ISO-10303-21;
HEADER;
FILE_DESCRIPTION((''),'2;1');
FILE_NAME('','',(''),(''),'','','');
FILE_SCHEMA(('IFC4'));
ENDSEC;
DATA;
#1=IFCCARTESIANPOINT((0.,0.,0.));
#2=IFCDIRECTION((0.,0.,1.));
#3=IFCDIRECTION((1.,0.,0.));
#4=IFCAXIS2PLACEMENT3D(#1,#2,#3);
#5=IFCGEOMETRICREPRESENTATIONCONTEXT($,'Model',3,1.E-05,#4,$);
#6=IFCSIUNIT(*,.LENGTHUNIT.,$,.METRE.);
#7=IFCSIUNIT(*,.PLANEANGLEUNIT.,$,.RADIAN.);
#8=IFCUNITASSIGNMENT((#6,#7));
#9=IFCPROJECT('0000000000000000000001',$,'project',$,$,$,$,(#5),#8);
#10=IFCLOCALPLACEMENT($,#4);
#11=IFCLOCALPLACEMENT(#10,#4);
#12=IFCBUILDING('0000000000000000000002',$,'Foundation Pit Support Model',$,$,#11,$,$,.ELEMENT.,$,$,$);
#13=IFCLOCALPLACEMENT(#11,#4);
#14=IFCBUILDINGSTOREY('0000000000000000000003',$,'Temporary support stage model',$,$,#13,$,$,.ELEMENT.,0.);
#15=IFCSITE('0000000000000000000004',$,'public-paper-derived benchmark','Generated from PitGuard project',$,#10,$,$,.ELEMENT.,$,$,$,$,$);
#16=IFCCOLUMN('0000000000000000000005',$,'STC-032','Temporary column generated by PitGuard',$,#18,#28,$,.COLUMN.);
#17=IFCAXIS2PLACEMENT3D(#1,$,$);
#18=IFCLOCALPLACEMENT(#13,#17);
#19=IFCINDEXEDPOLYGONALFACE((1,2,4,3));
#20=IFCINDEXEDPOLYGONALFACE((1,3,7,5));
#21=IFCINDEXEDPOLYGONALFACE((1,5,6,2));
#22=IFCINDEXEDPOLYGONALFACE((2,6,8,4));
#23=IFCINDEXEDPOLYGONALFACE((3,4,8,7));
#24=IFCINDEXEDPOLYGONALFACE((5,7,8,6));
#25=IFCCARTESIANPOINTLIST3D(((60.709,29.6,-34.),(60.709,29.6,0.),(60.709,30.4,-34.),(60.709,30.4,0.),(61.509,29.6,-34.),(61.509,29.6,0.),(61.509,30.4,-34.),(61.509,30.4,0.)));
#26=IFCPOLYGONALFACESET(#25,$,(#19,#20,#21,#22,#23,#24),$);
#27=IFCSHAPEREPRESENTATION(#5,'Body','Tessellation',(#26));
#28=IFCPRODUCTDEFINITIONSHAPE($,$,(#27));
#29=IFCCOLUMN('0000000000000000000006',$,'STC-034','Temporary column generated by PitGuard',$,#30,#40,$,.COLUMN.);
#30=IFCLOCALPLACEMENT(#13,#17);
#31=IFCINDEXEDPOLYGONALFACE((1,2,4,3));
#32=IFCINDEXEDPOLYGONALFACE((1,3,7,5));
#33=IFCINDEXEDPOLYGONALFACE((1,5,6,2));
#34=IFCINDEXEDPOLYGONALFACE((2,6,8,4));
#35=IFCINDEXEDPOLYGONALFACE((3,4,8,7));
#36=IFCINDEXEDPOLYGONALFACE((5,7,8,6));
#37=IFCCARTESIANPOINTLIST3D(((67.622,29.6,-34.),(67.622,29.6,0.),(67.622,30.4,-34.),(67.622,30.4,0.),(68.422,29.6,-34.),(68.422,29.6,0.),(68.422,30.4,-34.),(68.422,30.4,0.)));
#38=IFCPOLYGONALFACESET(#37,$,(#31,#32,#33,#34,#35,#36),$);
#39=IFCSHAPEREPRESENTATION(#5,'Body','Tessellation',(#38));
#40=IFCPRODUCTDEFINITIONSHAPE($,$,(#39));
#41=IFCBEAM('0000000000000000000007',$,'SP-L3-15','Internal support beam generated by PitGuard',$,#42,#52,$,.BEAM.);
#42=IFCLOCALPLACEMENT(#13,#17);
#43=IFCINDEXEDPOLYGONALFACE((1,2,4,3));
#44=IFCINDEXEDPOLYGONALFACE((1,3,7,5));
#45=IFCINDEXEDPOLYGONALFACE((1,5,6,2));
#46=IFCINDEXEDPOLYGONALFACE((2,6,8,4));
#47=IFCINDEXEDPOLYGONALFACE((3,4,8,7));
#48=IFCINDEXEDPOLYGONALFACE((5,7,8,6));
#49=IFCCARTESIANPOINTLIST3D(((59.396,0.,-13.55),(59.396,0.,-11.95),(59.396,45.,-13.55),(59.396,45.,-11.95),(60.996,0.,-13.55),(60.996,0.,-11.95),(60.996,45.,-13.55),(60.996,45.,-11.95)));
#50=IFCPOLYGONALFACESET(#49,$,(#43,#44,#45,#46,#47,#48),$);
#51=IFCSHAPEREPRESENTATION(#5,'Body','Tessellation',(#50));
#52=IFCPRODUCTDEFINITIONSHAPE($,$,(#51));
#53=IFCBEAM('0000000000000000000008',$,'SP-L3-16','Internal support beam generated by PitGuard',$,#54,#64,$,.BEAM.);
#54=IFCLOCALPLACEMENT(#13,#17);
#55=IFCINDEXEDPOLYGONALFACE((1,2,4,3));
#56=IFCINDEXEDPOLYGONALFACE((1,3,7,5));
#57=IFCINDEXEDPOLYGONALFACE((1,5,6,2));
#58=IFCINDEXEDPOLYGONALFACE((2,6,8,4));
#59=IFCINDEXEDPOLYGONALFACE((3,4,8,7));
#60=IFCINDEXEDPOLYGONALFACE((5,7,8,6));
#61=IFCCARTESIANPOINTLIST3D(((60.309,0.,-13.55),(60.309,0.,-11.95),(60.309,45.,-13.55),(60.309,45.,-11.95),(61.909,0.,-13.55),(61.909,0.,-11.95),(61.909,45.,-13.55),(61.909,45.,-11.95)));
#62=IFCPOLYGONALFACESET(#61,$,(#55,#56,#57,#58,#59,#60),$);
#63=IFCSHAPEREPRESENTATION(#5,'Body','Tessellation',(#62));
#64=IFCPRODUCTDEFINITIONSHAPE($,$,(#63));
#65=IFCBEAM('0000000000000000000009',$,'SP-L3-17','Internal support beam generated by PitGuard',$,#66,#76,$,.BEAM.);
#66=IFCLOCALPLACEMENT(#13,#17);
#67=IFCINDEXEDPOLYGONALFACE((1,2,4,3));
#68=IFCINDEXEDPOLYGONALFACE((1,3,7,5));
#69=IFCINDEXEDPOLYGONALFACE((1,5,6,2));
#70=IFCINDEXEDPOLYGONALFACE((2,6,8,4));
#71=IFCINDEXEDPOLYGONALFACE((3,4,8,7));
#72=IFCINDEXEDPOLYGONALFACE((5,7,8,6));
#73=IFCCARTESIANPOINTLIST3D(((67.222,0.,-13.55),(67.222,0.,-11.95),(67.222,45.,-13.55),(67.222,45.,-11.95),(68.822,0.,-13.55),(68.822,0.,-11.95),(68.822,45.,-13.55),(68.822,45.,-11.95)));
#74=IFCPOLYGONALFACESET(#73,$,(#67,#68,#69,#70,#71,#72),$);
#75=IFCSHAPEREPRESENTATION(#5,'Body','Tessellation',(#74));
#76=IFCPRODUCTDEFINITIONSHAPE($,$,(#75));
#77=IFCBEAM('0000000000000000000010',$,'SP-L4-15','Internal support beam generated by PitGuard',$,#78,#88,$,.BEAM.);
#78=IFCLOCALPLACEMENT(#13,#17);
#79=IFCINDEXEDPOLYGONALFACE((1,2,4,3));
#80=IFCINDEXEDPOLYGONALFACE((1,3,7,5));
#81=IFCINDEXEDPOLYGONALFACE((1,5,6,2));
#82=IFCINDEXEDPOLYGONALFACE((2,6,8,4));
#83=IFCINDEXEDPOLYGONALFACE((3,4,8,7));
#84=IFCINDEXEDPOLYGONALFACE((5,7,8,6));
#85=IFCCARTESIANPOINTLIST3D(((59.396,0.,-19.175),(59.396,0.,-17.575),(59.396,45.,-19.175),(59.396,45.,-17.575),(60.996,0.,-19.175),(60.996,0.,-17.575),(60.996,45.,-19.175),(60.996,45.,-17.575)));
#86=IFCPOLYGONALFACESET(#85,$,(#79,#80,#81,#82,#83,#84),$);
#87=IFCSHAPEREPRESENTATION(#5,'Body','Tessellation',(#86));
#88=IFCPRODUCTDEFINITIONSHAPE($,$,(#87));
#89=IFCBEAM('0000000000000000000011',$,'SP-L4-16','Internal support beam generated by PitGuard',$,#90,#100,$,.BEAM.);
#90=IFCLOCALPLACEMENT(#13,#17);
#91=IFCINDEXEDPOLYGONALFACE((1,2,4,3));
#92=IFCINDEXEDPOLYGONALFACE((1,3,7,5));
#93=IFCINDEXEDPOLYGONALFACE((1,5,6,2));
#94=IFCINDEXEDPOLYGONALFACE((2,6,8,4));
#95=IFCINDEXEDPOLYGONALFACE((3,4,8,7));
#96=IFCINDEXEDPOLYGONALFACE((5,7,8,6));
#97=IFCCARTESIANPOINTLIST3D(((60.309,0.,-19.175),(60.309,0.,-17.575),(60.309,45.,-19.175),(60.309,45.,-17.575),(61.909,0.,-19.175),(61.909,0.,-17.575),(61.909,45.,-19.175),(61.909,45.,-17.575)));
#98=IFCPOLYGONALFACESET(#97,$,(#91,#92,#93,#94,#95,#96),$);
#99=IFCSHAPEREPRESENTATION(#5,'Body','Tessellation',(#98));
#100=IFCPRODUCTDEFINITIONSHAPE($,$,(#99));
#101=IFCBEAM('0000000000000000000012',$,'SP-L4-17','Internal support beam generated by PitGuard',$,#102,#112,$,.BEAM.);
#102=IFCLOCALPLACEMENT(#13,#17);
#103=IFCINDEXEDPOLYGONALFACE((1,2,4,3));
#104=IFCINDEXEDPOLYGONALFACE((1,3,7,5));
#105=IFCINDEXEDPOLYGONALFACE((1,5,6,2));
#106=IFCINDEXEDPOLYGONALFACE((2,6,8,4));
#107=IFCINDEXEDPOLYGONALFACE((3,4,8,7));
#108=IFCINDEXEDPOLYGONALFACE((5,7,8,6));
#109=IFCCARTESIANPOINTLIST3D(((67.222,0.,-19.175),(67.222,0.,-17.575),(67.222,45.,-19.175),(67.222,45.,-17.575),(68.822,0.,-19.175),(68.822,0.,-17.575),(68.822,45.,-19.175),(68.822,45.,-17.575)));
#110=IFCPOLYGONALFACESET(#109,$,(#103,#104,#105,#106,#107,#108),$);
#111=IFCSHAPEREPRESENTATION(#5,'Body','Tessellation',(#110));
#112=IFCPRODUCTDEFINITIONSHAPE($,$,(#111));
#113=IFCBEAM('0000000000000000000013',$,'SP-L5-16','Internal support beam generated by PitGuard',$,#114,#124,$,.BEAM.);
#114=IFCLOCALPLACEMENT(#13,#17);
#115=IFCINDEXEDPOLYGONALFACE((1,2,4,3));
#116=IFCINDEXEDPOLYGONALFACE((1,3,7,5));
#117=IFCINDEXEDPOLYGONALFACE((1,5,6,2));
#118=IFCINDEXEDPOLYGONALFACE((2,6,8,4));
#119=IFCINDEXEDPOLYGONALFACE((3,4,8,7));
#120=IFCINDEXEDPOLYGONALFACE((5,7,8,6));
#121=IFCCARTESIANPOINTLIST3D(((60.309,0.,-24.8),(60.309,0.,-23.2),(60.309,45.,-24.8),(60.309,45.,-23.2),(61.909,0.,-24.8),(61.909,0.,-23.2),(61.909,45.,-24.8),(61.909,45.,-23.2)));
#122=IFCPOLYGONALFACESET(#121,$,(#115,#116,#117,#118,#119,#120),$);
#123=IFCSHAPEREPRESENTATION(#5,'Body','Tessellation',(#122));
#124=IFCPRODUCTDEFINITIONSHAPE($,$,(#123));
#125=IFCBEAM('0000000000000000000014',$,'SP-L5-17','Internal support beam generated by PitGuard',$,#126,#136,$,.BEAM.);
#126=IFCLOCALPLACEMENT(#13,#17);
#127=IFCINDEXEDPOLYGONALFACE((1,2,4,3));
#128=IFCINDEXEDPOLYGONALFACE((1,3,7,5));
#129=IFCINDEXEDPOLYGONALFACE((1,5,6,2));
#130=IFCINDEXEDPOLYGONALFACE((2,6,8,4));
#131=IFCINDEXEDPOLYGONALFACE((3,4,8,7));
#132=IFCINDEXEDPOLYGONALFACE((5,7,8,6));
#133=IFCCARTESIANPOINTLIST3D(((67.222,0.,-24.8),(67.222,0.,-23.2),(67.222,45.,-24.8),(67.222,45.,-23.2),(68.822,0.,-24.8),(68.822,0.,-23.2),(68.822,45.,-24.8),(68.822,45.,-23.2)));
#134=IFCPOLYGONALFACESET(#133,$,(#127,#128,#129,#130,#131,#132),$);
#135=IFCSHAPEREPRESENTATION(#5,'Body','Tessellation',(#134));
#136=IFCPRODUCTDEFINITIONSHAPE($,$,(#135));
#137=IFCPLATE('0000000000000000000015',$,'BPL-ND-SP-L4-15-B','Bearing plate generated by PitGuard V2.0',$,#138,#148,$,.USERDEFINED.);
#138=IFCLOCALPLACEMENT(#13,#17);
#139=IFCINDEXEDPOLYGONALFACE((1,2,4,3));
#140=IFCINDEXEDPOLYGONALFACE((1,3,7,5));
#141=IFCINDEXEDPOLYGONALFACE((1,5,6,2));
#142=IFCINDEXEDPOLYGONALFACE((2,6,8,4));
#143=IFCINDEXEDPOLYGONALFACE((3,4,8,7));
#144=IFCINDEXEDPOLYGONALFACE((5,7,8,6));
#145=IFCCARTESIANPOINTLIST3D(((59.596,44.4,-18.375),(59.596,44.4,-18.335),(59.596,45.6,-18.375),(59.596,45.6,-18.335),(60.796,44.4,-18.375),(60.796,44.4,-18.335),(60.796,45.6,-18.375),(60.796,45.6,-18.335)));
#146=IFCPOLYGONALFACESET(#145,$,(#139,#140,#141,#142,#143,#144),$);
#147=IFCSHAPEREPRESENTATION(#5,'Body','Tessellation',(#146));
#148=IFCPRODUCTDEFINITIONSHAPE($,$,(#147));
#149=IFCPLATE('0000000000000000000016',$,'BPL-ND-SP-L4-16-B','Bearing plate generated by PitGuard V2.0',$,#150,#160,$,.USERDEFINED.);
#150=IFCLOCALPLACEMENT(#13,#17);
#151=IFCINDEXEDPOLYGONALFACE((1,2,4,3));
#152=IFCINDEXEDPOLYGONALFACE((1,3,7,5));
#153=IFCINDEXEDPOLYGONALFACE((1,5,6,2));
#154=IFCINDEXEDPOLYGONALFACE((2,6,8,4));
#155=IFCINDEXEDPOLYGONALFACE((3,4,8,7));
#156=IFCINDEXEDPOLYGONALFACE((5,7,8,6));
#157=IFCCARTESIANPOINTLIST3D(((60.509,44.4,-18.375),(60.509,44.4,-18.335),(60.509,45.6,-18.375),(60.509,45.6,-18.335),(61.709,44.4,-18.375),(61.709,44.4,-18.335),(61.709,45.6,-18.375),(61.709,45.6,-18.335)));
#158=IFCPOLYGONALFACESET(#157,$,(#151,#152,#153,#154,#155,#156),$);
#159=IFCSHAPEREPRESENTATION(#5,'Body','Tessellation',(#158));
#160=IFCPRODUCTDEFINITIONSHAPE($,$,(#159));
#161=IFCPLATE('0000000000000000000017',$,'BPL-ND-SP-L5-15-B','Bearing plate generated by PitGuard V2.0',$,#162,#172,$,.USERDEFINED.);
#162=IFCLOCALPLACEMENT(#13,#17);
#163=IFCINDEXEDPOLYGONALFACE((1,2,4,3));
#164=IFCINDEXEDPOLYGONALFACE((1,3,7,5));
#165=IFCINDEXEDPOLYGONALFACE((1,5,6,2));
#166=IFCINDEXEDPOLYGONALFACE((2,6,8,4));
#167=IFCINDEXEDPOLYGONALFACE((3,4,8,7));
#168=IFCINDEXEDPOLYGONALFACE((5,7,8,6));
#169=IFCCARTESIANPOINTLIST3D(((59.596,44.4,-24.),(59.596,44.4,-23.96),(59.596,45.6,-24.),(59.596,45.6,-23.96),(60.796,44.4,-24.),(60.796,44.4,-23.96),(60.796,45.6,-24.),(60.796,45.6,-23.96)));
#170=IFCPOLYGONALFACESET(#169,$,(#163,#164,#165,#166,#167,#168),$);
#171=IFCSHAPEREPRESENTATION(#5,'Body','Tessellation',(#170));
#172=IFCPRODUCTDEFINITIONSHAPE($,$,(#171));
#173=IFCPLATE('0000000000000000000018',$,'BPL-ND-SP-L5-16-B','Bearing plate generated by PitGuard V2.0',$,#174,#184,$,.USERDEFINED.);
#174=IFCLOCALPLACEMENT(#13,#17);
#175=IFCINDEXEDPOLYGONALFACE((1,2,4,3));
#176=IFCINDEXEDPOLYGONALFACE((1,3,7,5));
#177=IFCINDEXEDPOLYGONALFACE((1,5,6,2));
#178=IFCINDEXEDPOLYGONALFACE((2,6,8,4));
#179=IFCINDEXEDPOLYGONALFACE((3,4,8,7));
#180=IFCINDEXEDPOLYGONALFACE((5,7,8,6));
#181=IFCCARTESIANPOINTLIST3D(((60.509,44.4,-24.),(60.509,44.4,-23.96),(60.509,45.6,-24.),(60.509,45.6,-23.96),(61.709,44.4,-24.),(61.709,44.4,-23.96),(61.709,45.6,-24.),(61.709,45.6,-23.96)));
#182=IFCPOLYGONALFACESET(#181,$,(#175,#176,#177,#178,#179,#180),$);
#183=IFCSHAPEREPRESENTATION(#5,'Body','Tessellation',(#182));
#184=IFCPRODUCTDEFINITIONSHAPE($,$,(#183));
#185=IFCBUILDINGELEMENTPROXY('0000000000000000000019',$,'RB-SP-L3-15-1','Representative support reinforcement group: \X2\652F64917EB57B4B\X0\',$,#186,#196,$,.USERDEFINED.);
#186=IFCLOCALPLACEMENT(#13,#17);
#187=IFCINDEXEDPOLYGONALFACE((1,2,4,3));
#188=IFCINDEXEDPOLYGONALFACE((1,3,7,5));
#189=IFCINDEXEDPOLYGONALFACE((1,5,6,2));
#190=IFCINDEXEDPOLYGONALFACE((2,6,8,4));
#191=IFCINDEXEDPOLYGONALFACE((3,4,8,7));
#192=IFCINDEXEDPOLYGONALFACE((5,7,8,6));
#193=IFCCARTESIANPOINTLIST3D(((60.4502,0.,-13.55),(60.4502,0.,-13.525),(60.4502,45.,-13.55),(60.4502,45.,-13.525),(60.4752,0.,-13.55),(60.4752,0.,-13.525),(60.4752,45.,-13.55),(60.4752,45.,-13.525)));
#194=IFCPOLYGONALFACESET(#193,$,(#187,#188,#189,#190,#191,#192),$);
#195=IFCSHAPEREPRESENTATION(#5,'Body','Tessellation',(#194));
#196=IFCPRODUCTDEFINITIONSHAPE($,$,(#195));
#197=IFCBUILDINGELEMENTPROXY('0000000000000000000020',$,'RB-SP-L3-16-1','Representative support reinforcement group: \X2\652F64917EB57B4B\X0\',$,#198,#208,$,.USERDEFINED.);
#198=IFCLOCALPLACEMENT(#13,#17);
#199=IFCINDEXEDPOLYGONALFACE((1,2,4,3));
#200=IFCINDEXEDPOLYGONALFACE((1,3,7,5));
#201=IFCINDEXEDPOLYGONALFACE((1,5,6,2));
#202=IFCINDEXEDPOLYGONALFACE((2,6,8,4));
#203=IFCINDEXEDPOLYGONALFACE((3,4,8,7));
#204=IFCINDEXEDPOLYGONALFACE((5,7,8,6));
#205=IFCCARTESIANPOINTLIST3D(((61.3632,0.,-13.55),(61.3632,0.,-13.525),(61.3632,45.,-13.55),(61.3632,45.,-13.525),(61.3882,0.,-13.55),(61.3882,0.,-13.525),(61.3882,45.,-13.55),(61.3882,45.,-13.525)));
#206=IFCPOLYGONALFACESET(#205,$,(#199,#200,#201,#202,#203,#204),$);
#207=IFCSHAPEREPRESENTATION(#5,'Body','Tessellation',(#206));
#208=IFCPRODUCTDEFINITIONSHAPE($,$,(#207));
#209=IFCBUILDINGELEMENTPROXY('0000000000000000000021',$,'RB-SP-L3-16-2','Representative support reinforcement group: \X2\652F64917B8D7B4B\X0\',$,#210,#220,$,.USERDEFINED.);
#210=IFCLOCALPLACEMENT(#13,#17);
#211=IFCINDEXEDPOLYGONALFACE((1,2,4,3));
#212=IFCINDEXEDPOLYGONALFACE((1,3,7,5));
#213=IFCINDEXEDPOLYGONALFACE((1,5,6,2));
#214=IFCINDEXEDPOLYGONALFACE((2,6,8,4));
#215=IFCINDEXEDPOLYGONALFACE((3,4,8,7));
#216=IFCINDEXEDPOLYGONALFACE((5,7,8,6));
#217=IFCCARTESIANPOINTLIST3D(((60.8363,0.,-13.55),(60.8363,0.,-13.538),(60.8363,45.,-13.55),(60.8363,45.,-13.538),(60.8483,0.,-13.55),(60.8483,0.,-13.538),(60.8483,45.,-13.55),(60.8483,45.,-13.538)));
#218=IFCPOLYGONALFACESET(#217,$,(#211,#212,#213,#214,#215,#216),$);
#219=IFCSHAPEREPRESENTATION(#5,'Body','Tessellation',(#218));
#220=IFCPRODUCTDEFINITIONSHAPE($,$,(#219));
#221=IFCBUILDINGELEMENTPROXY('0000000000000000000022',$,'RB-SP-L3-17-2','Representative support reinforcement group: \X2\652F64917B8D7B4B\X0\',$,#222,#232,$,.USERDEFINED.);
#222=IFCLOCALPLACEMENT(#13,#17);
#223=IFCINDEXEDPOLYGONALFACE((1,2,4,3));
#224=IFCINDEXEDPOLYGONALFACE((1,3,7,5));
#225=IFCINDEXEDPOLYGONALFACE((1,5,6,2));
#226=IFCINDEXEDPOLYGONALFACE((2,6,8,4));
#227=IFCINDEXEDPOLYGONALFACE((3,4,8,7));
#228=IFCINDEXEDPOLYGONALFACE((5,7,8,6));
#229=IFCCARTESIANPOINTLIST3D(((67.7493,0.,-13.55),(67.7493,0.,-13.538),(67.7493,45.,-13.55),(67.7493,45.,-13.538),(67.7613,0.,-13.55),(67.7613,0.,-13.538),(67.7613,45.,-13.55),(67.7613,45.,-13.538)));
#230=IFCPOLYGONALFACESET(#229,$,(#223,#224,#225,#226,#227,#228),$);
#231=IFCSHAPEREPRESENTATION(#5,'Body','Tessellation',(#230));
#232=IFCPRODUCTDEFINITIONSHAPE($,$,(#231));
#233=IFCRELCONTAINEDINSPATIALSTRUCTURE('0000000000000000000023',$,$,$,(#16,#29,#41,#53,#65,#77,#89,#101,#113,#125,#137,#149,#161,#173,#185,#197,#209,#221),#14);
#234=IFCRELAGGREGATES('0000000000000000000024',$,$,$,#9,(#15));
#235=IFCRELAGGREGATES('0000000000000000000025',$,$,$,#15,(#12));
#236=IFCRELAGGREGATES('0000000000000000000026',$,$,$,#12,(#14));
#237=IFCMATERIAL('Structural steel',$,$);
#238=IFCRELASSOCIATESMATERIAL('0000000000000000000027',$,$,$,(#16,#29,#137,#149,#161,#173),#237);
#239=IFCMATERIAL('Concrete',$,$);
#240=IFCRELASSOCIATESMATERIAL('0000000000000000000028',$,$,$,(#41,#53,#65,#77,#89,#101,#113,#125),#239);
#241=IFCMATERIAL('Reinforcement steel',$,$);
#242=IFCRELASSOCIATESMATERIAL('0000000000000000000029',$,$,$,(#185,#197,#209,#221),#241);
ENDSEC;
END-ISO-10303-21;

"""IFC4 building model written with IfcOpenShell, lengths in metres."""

from ifc_helpers import new_model, si_unit, frame, origin_with_axes, origin_2d, place, context, project, spatial, rectangle, extrude, material, element, save


model = new_model("IFC4")

# Units and contexts
model_context = context("Model", 3, precision=1e-05, world=origin_with_axes())
ifc_project = project(units=[si_unit("LENGTHUNIT", "METRE"), si_unit("PLANEANGLEUNIT", "RADIAN")], contexts=[model_context])

# Site, building, storey
site_placement = place(None, origin_with_axes())
site = spatial("IfcSite", under=ifc_project, at=site_placement, Name="public-paper-derived benchmark", Description="Generated from PitGuard project", CompositionType="ELEMENT")
building_placement = place(site_placement, origin_with_axes())
building = spatial("IfcBuilding", under=site, at=building_placement, Name="Foundation Pit Support Model", CompositionType="ELEMENT")
storey_placement = place(building_placement, origin_with_axes())
storey = spatial("IfcBuildingStorey", under=building, at=storey_placement, Name="Temporary support stage model", CompositionType="ELEMENT", Elevation=0.0)

# Columns
ifc_material_1 = material(Name="Structural steel")
for number, where, z_axis, x_axis, name in (
    (1, (61.109, 30.0, -34.0), (0.0, 0.0, 1.0), (1.0, 0.0, 0.0), "STC-032"),
    (2, (68.022, 30.0, -34.0), (0.0, 0.0, 1.0), (1.0, 0.0, 0.0), "STC-034"),
):
    element("IfcColumn", number, at=place(storey_placement, frame(where, z_axis=z_axis, x_axis=x_axis)), inside=storey, material=ifc_material_1, Name=name, Description="Temporary column generated by PitGuard", PredefinedType="COLUMN", context=model_context, shape_type="SweptSolid", body=[
        extrude(rectangle(XDim=0.8, YDim=0.8, at=origin_2d()), origin_with_axes(), (0.0, 0.0, 1.0), 34.0),
    ])

# Beams
ifc_material_2 = material(Name="Concrete")
for number, where, z_axis, x_axis, name in (
    (3, (60.196, 22.5, -13.55), (0.0, 0.0, 1.0), (0.0, 1.0, 0.0), "SP-L3-15"),
    (4, (61.109, 22.5, -13.55), (0.0, 0.0, 1.0), (0.0, 1.0, 0.0), "SP-L3-16"),
    (5, (68.022, 22.5, -13.55), (0.0, 0.0, 1.0), (0.0, 1.0, 0.0), "SP-L3-17"),
    (6, (60.196, 22.5, -19.175), (0.0, 0.0, 1.0), (0.0, 1.0, 0.0), "SP-L4-15"),
    (7, (61.109, 22.5, -19.175), (0.0, 0.0, 1.0), (0.0, 1.0, 0.0), "SP-L4-16"),
    (8, (68.022, 22.5, -19.175), (0.0, 0.0, 1.0), (0.0, 1.0, 0.0), "SP-L4-17"),
    (9, (61.109, 22.5, -24.8), (0.0, 0.0, 1.0), (0.0, 1.0, 0.0), "SP-L5-16"),
    (10, (68.022, 22.5, -24.8), (0.0, 0.0, 1.0), (0.0, 1.0, 0.0), "SP-L5-17"),
):
    element("IfcBeam", number, at=place(storey_placement, frame(where, z_axis=z_axis, x_axis=x_axis)), inside=storey, material=ifc_material_2, Name=name, Description="Internal support beam generated by PitGuard", PredefinedType="BEAM", context=model_context, shape_type="SweptSolid", body=[
        extrude(rectangle(XDim=45.0, YDim=1.6, at=origin_2d()), origin_with_axes(), (0.0, 0.0, 1.0), 1.6),
    ])

# Plates
for number, where, z_axis, x_axis, name in (
    (11, (60.196, 45.0, -18.375), (0.0, 0.0, 1.0), (1.0, 0.0, 0.0), "BPL-ND-SP-L4-15-B"),
    (12, (61.109, 45.0, -18.375), (0.0, 0.0, 1.0), (1.0, 0.0, 0.0), "BPL-ND-SP-L4-16-B"),
    (13, (60.196, 45.0, -24.0), (0.0, 0.0, 1.0), (1.0, 0.0, 0.0), "BPL-ND-SP-L5-15-B"),
    (14, (61.109, 45.0, -24.0), (0.0, 0.0, 1.0), (1.0, 0.0, 0.0), "BPL-ND-SP-L5-16-B"),
):
    element("IfcPlate", number, at=place(storey_placement, frame(where, z_axis=z_axis, x_axis=x_axis)), inside=storey, material=ifc_material_1, Name=name, Description="Bearing plate generated by PitGuard V2.0", PredefinedType="USERDEFINED", context=model_context, shape_type="SweptSolid", body=[
        extrude(rectangle(XDim=1.2, YDim=1.2, at=origin_2d()), origin_with_axes(), (0.0, 0.0, 1.0), 0.04),
    ])

# Building element proxies
ifc_material_3 = material(Name="Reinforcement steel")
for number, where, z_axis, x_axis, name in (
    (15, (60.4627, 22.5, -13.55), (0.0, 0.0, 1.0), (0.0, 1.0, 0.0), "RB-SP-L3-15-1"),
    (16, (61.3757, 22.5, -13.55), (0.0, 0.0, 1.0), (0.0, 1.0, 0.0), "RB-SP-L3-16-1"),
):
    element("IfcBuildingElementProxy", number, at=place(storey_placement, frame(where, z_axis=z_axis, x_axis=x_axis)), inside=storey, material=ifc_material_3, Name=name, Description="Representative support reinforcement group: 支撑纵筋", PredefinedType="USERDEFINED", context=model_context, shape_type="SweptSolid", body=[
        extrude(rectangle(XDim=45.0, YDim=0.025, at=origin_2d()), origin_with_axes(), (0.0, 0.0, 1.0), 0.025),
    ])
for number, where, z_axis, x_axis, name in (
    (17, (60.8423, 22.5, -13.55), (0.0, 0.0, 1.0), (0.0, 1.0, 0.0), "RB-SP-L3-16-2"),
    (18, (67.7553, 22.5, -13.55), (0.0, 0.0, 1.0), (0.0, 1.0, 0.0), "RB-SP-L3-17-2"),
):
    element("IfcBuildingElementProxy", number, at=place(storey_placement, frame(where, z_axis=z_axis, x_axis=x_axis)), inside=storey, material=ifc_material_3, Name=name, Description="Representative support reinforcement group: 支撑箍筋", PredefinedType="USERDEFINED", context=model_context, shape_type="SweptSolid", body=[
        extrude(rectangle(XDim=45.0, YDim=0.012, at=origin_2d()), origin_with_axes(), (0.0, 0.0, 1.0), 0.012),
    ])

save(model, "model.ifc")
